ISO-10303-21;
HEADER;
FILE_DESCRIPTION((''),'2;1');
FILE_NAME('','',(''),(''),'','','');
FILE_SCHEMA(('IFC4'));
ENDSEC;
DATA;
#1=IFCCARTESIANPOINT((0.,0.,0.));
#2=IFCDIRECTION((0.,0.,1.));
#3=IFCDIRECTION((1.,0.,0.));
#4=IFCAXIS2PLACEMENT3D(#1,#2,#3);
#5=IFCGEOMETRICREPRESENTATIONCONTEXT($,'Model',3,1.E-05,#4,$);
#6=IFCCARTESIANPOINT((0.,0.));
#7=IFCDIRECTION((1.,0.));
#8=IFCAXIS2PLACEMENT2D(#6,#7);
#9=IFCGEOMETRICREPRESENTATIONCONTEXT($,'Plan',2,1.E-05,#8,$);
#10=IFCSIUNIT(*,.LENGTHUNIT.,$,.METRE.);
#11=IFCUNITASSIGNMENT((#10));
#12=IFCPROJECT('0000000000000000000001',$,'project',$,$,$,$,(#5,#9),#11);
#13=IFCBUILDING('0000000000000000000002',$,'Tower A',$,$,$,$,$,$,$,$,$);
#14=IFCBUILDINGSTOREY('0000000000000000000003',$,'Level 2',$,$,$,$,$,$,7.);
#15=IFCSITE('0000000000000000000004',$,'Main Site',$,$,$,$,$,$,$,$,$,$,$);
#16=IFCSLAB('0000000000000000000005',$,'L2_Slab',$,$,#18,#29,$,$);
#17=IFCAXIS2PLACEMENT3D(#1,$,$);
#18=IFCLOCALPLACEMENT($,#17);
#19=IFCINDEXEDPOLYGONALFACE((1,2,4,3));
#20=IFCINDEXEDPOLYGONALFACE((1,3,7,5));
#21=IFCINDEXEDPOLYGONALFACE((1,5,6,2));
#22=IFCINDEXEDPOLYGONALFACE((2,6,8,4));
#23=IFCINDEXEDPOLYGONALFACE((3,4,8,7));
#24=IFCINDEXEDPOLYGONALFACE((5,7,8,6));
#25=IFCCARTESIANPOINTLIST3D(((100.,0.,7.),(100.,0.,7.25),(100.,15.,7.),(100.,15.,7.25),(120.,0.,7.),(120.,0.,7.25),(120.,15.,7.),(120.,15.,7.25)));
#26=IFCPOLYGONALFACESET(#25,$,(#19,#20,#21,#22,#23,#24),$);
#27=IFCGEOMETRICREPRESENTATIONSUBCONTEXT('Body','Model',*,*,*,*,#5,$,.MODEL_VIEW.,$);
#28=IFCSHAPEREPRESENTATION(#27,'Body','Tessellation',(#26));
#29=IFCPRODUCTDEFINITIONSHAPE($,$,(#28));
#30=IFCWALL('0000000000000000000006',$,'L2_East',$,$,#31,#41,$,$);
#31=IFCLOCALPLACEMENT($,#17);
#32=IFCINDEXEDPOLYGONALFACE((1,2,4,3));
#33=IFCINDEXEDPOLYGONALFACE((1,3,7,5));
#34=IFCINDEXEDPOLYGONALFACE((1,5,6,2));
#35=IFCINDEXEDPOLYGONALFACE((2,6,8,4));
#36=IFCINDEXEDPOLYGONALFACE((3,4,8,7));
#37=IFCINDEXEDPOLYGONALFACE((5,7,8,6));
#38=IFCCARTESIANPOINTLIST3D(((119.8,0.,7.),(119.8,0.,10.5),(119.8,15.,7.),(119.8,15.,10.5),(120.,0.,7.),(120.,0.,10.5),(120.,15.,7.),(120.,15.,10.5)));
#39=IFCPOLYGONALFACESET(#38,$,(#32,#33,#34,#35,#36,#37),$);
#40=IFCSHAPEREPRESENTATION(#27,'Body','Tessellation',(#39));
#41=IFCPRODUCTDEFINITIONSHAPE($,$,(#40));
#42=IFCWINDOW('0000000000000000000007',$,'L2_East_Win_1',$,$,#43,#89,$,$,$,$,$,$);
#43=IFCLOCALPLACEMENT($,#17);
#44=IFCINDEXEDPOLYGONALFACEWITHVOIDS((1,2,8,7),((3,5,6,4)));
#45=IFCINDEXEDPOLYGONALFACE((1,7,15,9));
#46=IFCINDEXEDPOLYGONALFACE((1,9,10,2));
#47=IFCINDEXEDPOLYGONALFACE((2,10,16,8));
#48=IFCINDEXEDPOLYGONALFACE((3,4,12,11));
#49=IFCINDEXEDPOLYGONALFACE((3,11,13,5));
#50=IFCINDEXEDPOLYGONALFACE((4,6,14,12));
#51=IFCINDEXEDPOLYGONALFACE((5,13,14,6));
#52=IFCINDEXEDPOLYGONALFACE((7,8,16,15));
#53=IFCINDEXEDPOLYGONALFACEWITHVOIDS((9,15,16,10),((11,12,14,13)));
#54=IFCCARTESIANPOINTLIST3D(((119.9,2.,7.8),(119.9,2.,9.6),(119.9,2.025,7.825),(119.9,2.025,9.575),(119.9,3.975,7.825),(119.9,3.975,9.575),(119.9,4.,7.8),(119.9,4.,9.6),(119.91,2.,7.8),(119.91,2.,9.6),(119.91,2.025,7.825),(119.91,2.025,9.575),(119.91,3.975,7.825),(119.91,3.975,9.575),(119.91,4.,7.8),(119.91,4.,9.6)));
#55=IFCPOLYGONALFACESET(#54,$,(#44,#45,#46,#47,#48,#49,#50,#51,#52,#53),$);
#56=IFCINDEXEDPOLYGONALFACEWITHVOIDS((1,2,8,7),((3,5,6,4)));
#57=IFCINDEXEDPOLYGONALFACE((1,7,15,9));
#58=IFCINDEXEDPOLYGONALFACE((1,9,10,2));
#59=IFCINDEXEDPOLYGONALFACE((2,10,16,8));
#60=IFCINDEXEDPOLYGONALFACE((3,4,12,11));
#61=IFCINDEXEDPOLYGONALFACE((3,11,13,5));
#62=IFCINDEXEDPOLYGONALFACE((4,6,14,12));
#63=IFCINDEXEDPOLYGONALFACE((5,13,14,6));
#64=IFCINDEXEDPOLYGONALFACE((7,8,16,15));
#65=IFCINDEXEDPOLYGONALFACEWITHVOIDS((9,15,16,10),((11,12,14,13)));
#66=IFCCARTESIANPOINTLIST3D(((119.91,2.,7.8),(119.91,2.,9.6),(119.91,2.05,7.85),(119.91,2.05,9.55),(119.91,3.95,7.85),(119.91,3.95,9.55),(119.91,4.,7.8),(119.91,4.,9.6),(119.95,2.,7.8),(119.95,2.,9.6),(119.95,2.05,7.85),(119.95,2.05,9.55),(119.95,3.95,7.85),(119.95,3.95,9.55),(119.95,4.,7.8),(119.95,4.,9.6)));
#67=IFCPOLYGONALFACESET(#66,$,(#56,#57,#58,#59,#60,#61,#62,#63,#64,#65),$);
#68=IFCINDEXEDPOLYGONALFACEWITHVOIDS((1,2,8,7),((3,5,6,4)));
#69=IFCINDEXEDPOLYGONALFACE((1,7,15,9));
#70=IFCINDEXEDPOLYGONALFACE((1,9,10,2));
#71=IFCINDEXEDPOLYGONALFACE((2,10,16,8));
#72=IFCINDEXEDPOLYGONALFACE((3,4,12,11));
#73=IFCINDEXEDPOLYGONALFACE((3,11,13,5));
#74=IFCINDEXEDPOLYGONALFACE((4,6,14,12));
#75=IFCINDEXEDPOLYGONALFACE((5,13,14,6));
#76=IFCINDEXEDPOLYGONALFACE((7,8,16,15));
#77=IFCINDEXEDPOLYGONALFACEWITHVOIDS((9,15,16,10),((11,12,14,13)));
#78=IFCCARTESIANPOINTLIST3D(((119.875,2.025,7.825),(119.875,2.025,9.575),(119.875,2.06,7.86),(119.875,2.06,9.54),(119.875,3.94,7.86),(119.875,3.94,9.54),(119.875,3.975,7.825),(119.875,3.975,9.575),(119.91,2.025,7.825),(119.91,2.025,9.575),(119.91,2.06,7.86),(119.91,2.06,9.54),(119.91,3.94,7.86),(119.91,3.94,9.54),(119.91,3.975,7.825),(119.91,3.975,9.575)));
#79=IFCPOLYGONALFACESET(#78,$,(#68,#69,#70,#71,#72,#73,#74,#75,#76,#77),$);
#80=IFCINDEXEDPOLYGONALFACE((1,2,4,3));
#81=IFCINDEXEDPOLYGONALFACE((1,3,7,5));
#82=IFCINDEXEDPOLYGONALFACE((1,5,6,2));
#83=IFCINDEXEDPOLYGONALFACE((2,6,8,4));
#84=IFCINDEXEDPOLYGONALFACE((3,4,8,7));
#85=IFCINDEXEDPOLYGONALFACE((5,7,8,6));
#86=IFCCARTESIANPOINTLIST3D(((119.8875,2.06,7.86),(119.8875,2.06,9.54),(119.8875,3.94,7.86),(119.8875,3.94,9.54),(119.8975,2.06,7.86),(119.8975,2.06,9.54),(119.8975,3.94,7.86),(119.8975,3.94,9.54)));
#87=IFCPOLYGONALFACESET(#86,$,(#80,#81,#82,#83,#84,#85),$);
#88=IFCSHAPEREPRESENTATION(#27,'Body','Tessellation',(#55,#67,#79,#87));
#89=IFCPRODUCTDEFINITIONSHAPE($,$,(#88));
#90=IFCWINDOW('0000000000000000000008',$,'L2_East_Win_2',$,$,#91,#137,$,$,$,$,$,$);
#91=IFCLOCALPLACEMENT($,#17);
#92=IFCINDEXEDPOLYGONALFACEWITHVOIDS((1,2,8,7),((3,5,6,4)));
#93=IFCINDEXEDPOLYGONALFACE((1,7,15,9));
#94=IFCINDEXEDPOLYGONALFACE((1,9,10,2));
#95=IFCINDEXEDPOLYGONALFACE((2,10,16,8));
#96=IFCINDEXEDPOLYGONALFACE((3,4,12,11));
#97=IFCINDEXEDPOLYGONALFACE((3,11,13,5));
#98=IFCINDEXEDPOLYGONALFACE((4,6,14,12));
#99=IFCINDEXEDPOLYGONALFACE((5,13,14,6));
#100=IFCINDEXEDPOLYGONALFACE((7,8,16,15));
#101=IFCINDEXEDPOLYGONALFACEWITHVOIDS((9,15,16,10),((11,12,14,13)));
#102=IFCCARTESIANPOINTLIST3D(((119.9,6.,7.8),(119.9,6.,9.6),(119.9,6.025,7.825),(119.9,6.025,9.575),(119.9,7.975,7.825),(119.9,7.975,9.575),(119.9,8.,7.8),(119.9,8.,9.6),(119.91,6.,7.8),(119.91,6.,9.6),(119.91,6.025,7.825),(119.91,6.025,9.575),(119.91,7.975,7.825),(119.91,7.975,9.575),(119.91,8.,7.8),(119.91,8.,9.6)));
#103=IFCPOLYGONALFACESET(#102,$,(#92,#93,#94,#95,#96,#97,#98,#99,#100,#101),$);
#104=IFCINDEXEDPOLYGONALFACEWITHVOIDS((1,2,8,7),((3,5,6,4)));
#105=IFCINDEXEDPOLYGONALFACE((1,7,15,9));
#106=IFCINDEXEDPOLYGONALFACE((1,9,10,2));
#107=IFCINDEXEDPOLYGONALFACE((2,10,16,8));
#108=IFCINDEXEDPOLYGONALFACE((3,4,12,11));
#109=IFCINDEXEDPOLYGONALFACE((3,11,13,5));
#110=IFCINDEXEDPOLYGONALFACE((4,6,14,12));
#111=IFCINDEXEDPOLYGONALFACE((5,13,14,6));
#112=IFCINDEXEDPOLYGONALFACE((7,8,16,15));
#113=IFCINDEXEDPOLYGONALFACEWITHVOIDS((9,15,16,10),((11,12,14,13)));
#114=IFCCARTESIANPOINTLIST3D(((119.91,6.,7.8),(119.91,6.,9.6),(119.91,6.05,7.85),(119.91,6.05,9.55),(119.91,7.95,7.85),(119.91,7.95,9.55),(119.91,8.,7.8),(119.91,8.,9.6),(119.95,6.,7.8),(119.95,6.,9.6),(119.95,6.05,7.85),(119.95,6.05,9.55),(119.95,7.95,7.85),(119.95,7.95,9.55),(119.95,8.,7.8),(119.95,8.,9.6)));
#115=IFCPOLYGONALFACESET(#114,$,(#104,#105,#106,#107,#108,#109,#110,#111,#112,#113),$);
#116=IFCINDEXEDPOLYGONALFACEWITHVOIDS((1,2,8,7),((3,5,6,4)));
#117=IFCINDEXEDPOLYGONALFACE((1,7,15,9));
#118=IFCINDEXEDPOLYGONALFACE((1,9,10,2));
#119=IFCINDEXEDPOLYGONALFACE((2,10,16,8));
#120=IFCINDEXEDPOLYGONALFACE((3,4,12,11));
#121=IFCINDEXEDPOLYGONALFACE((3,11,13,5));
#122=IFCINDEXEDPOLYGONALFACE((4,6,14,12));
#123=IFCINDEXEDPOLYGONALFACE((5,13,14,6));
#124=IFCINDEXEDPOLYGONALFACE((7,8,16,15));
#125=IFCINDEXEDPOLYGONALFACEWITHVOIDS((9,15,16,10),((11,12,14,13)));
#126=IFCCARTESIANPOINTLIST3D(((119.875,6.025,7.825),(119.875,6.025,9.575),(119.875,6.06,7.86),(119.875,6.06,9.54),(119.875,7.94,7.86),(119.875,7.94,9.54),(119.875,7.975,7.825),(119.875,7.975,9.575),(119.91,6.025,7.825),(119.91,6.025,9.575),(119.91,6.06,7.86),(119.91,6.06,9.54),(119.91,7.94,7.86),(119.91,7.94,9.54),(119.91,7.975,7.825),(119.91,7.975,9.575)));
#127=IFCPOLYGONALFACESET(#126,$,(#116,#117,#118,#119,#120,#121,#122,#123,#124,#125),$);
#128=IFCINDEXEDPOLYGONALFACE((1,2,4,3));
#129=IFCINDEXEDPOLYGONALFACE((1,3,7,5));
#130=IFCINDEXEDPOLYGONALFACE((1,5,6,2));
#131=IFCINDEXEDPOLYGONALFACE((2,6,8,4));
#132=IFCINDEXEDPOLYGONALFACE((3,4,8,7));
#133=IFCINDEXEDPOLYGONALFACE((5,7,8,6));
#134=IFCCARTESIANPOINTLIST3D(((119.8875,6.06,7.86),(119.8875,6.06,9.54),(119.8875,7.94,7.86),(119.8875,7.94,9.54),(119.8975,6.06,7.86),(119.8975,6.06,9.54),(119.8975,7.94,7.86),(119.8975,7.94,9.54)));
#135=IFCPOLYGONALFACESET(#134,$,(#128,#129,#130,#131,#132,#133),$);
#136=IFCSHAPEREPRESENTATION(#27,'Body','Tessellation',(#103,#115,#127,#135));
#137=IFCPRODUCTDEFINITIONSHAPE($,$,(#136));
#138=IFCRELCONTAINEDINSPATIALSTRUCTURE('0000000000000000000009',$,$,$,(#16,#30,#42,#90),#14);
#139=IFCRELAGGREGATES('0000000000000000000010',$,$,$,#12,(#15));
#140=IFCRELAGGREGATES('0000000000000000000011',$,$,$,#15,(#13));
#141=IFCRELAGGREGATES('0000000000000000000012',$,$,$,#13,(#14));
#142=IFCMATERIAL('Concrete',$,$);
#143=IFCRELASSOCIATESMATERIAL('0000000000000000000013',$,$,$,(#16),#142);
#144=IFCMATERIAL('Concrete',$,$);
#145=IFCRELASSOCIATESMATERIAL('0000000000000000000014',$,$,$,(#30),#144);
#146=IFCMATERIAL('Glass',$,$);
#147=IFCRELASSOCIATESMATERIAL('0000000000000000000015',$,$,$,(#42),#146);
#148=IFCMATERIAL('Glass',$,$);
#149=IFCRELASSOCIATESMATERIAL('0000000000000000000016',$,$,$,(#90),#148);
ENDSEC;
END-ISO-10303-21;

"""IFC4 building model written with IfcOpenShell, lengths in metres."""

from ifc_helpers import new_model, si_unit, frame, origin_with_axes, origin_2d_with_axis, place, context, subcontext, project, spatial, line, indexed_curve, outline, extrude, material, element, fill, save


model = new_model("IFC4")

# Units and contexts
model_context = context("Model", 3, precision=1e-05, world=origin_with_axes())
plan_context = context("Plan", 2, precision=1e-05, world=origin_2d_with_axis())
body_context = subcontext(model_context, "Body", "Model", "MODEL_VIEW")
ifc_project = project(units=[si_unit("LENGTHUNIT", "METRE")], contexts=[model_context, plan_context])

# Site, building, storey
site = spatial("IfcSite", under=ifc_project, Name="Main Site")
building = spatial("IfcBuilding", under=site, Name="Tower A")
storey = spatial("IfcBuildingStorey", under=building, Name="Level 2", Elevation=7.0)

# Slab
ifc_material_1 = material(Name="Concrete")
slab_placement = place(None, frame((100.0, 0.0, 7.0), z_axis=(0.0, 0.0, 1.0), x_axis=(1.0, 0.0, 0.0)))
element("IfcSlab", 1, at=slab_placement, inside=storey, material=ifc_material_1, Name="L2_Slab", context=body_context, shape_type="SweptSolid", body=[
    extrude(outline(indexed_curve([(0.0, 0.0), (20.0, 0.0), (20.0, 15.0), (0.0, 15.0)])), None, (0.0, 0.0, 1.0), 0.25),
])

# Wall, openings, windows
ifc_material_2 = material(Name="Concrete")
wall_1_placement = place(None, frame((120.0, 0.0, 7.0), z_axis=(0.0, 0.0, 1.0), x_axis=(0.0, 1.0, 0.0)))
wall_1 = element("IfcWall", 2, at=wall_1_placement, inside=storey, material=ifc_material_2, Name="L2_East", context=body_context, shape_type="SweptSolid", body=[
    extrude(outline(indexed_curve([(0.0, 0.0), (0.0, 0.2), (15.0, 0.2), (15.0, 0.0), (0.0, 0.0)], self_intersect=False)), origin_with_axes(), (0.0, 0.0, 1.0), 3.5),
])
opening_1_placement = place(wall_1_placement, frame((2.0, 0.0, 0.8), z_axis=(0.0, 0.0, 1.0), x_axis=(0.0, -1.0, 0.0)))
opening_1 = element("IfcOpeningElement", 3, at=opening_1_placement, cuts=wall_1, context=body_context, shape_type="SweptSolid", body=[
    extrude(outline(indexed_curve([(0.0, 0.0), (0.0, 0.25), (2.0, 0.25), (2.0, 0.0), (0.0, 0.0)], self_intersect=False)), origin_with_axes(), (0.0, 0.0, 1.0), 1.8),
])
opening_2_placement = place(wall_1_placement, frame((6.0, 0.0, 0.8), z_axis=(0.0, 0.0, 1.0), x_axis=(0.0, -1.0, 0.0)))
opening_2 = element("IfcOpeningElement", 4, at=opening_2_placement, cuts=wall_1, context=body_context, shape_type="SweptSolid", body=[
    extrude(outline(indexed_curve([(0.0, 0.0), (0.0, 0.25), (2.0, 0.25), (2.0, 0.0), (0.0, 0.0)], self_intersect=False)), origin_with_axes(), (0.0, 0.0, 1.0), 1.8),
])
ifc_material_3 = material(Name="Glass")
window_1_placement = place(None, frame((120.0, 2.0, 7.8), z_axis=(0.0, 0.0, 1.0), x_axis=(0.0, 1.0, 0.0)))
window_1 = element("IfcWindow", 5, at=window_1_placement, inside=storey, material=ifc_material_3, Name="L2_East_Win_1", context=body_context, shape_type="SweptSolid", body=[
    extrude(outline(indexed_curve([(0.0, 0.0), (2.0, 0.0), (2.0, 1.8), (0.0, 1.8)], segments=[line(1, 2, 3, 4, 1)]), holes=[indexed_curve([(0.025, 0.025), (1.975, 0.025), (1.975, 1.775), (0.025, 1.775)], segments=[line(1, 2, 3, 4, 1)])]), frame((0.0, 0.09, 0.0), z_axis=(0.0, -1.0, 0.0), x_axis=(1.0, 0.0, 0.0)), (0.0, 0.0, -1.0), 0.01),
    extrude(outline(indexed_curve([(0.0, 0.0), (2.0, 0.0), (2.0, 1.8), (0.0, 1.8)], segments=[line(1, 2, 3, 4, 1)]), holes=[indexed_curve([(0.05, 0.05), (1.95, 0.05), (1.95, 1.75), (0.05, 1.75)], segments=[line(1, 2, 3, 4, 1)])]), frame((0.0, 0.05, 0.0), z_axis=(0.0, -1.0, 0.0), x_axis=(1.0, 0.0, 0.0)), (0.0, 0.0, -1.0), 0.04),
    extrude(outline(indexed_curve([(0.0, 0.0), (1.95, 0.0), (1.95, 1.75), (0.0, 1.75)], segments=[line(1, 2, 3, 4, 1)]), holes=[indexed_curve([(0.035, 0.035), (1.915, 0.035), (1.915, 1.715), (0.035, 1.715)], segments=[line(1, 2, 3, 4, 1)])]), frame((0.025, 0.09, 0.025), z_axis=(0.0, -1.0, 0.0), x_axis=(1.0, 0.0, 0.0)), (0.0, 0.0, -1.0), 0.035),
    extrude(outline(indexed_curve([(0.035, 0.035), (1.915, 0.035), (1.915, 1.715), (0.035, 1.715)], segments=[line(1, 2, 3, 4, 1)])), frame((0.025, 0.1025, 0.025), z_axis=(0.0, -1.0, 0.0), x_axis=(1.0, 0.0, 0.0)), (0.0, 0.0, -1.0), 0.01),
])
fill(opening_1, window_1)
ifc_material_4 = material(Name="Glass")
window_2_placement = place(None, frame((120.0, 6.0, 7.8), z_axis=(0.0, 0.0, 1.0), x_axis=(0.0, 1.0, 0.0)))
window_2 = element("IfcWindow", 6, at=window_2_placement, inside=storey, material=ifc_material_4, Name="L2_East_Win_2", context=body_context, shape_type="SweptSolid", body=[
    extrude(outline(indexed_curve([(0.0, 0.0), (2.0, 0.0), (2.0, 1.8), (0.0, 1.8)], segments=[line(1, 2, 3, 4, 1)]), holes=[indexed_curve([(0.025, 0.025), (1.975, 0.025), (1.975, 1.775), (0.025, 1.775)], segments=[line(1, 2, 3, 4, 1)])]), frame((0.0, 0.09, 0.0), z_axis=(0.0, -1.0, 0.0), x_axis=(1.0, 0.0, 0.0)), (0.0, 0.0, -1.0), 0.01),
    extrude(outline(indexed_curve([(0.0, 0.0), (2.0, 0.0), (2.0, 1.8), (0.0, 1.8)], segments=[line(1, 2, 3, 4, 1)]), holes=[indexed_curve([(0.05, 0.05), (1.95, 0.05), (1.95, 1.75), (0.05, 1.75)], segments=[line(1, 2, 3, 4, 1)])]), frame((0.0, 0.05, 0.0), z_axis=(0.0, -1.0, 0.0), x_axis=(1.0, 0.0, 0.0)), (0.0, 0.0, -1.0), 0.04),
    extrude(outline(indexed_curve([(0.0, 0.0), (1.95, 0.0), (1.95, 1.75), (0.0, 1.75)], segments=[line(1, 2, 3, 4, 1)]), holes=[indexed_curve([(0.035, 0.035), (1.915, 0.035), (1.915, 1.715), (0.035, 1.715)], segments=[line(1, 2, 3, 4, 1)])]), frame((0.025, 0.09, 0.025), z_axis=(0.0, -1.0, 0.0), x_axis=(1.0, 0.0, 0.0)), (0.0, 0.0, -1.0), 0.035),
    extrude(outline(indexed_curve([(0.035, 0.035), (1.915, 0.035), (1.915, 1.715), (0.035, 1.715)], segments=[line(1, 2, 3, 4, 1)])), frame((0.025, 0.1025, 0.025), z_axis=(0.0, -1.0, 0.0), x_axis=(1.0, 0.0, 0.0)), (0.0, 0.0, -1.0), 0.01),
])
fill(opening_2, window_2)

save(model, "model.ifc")
